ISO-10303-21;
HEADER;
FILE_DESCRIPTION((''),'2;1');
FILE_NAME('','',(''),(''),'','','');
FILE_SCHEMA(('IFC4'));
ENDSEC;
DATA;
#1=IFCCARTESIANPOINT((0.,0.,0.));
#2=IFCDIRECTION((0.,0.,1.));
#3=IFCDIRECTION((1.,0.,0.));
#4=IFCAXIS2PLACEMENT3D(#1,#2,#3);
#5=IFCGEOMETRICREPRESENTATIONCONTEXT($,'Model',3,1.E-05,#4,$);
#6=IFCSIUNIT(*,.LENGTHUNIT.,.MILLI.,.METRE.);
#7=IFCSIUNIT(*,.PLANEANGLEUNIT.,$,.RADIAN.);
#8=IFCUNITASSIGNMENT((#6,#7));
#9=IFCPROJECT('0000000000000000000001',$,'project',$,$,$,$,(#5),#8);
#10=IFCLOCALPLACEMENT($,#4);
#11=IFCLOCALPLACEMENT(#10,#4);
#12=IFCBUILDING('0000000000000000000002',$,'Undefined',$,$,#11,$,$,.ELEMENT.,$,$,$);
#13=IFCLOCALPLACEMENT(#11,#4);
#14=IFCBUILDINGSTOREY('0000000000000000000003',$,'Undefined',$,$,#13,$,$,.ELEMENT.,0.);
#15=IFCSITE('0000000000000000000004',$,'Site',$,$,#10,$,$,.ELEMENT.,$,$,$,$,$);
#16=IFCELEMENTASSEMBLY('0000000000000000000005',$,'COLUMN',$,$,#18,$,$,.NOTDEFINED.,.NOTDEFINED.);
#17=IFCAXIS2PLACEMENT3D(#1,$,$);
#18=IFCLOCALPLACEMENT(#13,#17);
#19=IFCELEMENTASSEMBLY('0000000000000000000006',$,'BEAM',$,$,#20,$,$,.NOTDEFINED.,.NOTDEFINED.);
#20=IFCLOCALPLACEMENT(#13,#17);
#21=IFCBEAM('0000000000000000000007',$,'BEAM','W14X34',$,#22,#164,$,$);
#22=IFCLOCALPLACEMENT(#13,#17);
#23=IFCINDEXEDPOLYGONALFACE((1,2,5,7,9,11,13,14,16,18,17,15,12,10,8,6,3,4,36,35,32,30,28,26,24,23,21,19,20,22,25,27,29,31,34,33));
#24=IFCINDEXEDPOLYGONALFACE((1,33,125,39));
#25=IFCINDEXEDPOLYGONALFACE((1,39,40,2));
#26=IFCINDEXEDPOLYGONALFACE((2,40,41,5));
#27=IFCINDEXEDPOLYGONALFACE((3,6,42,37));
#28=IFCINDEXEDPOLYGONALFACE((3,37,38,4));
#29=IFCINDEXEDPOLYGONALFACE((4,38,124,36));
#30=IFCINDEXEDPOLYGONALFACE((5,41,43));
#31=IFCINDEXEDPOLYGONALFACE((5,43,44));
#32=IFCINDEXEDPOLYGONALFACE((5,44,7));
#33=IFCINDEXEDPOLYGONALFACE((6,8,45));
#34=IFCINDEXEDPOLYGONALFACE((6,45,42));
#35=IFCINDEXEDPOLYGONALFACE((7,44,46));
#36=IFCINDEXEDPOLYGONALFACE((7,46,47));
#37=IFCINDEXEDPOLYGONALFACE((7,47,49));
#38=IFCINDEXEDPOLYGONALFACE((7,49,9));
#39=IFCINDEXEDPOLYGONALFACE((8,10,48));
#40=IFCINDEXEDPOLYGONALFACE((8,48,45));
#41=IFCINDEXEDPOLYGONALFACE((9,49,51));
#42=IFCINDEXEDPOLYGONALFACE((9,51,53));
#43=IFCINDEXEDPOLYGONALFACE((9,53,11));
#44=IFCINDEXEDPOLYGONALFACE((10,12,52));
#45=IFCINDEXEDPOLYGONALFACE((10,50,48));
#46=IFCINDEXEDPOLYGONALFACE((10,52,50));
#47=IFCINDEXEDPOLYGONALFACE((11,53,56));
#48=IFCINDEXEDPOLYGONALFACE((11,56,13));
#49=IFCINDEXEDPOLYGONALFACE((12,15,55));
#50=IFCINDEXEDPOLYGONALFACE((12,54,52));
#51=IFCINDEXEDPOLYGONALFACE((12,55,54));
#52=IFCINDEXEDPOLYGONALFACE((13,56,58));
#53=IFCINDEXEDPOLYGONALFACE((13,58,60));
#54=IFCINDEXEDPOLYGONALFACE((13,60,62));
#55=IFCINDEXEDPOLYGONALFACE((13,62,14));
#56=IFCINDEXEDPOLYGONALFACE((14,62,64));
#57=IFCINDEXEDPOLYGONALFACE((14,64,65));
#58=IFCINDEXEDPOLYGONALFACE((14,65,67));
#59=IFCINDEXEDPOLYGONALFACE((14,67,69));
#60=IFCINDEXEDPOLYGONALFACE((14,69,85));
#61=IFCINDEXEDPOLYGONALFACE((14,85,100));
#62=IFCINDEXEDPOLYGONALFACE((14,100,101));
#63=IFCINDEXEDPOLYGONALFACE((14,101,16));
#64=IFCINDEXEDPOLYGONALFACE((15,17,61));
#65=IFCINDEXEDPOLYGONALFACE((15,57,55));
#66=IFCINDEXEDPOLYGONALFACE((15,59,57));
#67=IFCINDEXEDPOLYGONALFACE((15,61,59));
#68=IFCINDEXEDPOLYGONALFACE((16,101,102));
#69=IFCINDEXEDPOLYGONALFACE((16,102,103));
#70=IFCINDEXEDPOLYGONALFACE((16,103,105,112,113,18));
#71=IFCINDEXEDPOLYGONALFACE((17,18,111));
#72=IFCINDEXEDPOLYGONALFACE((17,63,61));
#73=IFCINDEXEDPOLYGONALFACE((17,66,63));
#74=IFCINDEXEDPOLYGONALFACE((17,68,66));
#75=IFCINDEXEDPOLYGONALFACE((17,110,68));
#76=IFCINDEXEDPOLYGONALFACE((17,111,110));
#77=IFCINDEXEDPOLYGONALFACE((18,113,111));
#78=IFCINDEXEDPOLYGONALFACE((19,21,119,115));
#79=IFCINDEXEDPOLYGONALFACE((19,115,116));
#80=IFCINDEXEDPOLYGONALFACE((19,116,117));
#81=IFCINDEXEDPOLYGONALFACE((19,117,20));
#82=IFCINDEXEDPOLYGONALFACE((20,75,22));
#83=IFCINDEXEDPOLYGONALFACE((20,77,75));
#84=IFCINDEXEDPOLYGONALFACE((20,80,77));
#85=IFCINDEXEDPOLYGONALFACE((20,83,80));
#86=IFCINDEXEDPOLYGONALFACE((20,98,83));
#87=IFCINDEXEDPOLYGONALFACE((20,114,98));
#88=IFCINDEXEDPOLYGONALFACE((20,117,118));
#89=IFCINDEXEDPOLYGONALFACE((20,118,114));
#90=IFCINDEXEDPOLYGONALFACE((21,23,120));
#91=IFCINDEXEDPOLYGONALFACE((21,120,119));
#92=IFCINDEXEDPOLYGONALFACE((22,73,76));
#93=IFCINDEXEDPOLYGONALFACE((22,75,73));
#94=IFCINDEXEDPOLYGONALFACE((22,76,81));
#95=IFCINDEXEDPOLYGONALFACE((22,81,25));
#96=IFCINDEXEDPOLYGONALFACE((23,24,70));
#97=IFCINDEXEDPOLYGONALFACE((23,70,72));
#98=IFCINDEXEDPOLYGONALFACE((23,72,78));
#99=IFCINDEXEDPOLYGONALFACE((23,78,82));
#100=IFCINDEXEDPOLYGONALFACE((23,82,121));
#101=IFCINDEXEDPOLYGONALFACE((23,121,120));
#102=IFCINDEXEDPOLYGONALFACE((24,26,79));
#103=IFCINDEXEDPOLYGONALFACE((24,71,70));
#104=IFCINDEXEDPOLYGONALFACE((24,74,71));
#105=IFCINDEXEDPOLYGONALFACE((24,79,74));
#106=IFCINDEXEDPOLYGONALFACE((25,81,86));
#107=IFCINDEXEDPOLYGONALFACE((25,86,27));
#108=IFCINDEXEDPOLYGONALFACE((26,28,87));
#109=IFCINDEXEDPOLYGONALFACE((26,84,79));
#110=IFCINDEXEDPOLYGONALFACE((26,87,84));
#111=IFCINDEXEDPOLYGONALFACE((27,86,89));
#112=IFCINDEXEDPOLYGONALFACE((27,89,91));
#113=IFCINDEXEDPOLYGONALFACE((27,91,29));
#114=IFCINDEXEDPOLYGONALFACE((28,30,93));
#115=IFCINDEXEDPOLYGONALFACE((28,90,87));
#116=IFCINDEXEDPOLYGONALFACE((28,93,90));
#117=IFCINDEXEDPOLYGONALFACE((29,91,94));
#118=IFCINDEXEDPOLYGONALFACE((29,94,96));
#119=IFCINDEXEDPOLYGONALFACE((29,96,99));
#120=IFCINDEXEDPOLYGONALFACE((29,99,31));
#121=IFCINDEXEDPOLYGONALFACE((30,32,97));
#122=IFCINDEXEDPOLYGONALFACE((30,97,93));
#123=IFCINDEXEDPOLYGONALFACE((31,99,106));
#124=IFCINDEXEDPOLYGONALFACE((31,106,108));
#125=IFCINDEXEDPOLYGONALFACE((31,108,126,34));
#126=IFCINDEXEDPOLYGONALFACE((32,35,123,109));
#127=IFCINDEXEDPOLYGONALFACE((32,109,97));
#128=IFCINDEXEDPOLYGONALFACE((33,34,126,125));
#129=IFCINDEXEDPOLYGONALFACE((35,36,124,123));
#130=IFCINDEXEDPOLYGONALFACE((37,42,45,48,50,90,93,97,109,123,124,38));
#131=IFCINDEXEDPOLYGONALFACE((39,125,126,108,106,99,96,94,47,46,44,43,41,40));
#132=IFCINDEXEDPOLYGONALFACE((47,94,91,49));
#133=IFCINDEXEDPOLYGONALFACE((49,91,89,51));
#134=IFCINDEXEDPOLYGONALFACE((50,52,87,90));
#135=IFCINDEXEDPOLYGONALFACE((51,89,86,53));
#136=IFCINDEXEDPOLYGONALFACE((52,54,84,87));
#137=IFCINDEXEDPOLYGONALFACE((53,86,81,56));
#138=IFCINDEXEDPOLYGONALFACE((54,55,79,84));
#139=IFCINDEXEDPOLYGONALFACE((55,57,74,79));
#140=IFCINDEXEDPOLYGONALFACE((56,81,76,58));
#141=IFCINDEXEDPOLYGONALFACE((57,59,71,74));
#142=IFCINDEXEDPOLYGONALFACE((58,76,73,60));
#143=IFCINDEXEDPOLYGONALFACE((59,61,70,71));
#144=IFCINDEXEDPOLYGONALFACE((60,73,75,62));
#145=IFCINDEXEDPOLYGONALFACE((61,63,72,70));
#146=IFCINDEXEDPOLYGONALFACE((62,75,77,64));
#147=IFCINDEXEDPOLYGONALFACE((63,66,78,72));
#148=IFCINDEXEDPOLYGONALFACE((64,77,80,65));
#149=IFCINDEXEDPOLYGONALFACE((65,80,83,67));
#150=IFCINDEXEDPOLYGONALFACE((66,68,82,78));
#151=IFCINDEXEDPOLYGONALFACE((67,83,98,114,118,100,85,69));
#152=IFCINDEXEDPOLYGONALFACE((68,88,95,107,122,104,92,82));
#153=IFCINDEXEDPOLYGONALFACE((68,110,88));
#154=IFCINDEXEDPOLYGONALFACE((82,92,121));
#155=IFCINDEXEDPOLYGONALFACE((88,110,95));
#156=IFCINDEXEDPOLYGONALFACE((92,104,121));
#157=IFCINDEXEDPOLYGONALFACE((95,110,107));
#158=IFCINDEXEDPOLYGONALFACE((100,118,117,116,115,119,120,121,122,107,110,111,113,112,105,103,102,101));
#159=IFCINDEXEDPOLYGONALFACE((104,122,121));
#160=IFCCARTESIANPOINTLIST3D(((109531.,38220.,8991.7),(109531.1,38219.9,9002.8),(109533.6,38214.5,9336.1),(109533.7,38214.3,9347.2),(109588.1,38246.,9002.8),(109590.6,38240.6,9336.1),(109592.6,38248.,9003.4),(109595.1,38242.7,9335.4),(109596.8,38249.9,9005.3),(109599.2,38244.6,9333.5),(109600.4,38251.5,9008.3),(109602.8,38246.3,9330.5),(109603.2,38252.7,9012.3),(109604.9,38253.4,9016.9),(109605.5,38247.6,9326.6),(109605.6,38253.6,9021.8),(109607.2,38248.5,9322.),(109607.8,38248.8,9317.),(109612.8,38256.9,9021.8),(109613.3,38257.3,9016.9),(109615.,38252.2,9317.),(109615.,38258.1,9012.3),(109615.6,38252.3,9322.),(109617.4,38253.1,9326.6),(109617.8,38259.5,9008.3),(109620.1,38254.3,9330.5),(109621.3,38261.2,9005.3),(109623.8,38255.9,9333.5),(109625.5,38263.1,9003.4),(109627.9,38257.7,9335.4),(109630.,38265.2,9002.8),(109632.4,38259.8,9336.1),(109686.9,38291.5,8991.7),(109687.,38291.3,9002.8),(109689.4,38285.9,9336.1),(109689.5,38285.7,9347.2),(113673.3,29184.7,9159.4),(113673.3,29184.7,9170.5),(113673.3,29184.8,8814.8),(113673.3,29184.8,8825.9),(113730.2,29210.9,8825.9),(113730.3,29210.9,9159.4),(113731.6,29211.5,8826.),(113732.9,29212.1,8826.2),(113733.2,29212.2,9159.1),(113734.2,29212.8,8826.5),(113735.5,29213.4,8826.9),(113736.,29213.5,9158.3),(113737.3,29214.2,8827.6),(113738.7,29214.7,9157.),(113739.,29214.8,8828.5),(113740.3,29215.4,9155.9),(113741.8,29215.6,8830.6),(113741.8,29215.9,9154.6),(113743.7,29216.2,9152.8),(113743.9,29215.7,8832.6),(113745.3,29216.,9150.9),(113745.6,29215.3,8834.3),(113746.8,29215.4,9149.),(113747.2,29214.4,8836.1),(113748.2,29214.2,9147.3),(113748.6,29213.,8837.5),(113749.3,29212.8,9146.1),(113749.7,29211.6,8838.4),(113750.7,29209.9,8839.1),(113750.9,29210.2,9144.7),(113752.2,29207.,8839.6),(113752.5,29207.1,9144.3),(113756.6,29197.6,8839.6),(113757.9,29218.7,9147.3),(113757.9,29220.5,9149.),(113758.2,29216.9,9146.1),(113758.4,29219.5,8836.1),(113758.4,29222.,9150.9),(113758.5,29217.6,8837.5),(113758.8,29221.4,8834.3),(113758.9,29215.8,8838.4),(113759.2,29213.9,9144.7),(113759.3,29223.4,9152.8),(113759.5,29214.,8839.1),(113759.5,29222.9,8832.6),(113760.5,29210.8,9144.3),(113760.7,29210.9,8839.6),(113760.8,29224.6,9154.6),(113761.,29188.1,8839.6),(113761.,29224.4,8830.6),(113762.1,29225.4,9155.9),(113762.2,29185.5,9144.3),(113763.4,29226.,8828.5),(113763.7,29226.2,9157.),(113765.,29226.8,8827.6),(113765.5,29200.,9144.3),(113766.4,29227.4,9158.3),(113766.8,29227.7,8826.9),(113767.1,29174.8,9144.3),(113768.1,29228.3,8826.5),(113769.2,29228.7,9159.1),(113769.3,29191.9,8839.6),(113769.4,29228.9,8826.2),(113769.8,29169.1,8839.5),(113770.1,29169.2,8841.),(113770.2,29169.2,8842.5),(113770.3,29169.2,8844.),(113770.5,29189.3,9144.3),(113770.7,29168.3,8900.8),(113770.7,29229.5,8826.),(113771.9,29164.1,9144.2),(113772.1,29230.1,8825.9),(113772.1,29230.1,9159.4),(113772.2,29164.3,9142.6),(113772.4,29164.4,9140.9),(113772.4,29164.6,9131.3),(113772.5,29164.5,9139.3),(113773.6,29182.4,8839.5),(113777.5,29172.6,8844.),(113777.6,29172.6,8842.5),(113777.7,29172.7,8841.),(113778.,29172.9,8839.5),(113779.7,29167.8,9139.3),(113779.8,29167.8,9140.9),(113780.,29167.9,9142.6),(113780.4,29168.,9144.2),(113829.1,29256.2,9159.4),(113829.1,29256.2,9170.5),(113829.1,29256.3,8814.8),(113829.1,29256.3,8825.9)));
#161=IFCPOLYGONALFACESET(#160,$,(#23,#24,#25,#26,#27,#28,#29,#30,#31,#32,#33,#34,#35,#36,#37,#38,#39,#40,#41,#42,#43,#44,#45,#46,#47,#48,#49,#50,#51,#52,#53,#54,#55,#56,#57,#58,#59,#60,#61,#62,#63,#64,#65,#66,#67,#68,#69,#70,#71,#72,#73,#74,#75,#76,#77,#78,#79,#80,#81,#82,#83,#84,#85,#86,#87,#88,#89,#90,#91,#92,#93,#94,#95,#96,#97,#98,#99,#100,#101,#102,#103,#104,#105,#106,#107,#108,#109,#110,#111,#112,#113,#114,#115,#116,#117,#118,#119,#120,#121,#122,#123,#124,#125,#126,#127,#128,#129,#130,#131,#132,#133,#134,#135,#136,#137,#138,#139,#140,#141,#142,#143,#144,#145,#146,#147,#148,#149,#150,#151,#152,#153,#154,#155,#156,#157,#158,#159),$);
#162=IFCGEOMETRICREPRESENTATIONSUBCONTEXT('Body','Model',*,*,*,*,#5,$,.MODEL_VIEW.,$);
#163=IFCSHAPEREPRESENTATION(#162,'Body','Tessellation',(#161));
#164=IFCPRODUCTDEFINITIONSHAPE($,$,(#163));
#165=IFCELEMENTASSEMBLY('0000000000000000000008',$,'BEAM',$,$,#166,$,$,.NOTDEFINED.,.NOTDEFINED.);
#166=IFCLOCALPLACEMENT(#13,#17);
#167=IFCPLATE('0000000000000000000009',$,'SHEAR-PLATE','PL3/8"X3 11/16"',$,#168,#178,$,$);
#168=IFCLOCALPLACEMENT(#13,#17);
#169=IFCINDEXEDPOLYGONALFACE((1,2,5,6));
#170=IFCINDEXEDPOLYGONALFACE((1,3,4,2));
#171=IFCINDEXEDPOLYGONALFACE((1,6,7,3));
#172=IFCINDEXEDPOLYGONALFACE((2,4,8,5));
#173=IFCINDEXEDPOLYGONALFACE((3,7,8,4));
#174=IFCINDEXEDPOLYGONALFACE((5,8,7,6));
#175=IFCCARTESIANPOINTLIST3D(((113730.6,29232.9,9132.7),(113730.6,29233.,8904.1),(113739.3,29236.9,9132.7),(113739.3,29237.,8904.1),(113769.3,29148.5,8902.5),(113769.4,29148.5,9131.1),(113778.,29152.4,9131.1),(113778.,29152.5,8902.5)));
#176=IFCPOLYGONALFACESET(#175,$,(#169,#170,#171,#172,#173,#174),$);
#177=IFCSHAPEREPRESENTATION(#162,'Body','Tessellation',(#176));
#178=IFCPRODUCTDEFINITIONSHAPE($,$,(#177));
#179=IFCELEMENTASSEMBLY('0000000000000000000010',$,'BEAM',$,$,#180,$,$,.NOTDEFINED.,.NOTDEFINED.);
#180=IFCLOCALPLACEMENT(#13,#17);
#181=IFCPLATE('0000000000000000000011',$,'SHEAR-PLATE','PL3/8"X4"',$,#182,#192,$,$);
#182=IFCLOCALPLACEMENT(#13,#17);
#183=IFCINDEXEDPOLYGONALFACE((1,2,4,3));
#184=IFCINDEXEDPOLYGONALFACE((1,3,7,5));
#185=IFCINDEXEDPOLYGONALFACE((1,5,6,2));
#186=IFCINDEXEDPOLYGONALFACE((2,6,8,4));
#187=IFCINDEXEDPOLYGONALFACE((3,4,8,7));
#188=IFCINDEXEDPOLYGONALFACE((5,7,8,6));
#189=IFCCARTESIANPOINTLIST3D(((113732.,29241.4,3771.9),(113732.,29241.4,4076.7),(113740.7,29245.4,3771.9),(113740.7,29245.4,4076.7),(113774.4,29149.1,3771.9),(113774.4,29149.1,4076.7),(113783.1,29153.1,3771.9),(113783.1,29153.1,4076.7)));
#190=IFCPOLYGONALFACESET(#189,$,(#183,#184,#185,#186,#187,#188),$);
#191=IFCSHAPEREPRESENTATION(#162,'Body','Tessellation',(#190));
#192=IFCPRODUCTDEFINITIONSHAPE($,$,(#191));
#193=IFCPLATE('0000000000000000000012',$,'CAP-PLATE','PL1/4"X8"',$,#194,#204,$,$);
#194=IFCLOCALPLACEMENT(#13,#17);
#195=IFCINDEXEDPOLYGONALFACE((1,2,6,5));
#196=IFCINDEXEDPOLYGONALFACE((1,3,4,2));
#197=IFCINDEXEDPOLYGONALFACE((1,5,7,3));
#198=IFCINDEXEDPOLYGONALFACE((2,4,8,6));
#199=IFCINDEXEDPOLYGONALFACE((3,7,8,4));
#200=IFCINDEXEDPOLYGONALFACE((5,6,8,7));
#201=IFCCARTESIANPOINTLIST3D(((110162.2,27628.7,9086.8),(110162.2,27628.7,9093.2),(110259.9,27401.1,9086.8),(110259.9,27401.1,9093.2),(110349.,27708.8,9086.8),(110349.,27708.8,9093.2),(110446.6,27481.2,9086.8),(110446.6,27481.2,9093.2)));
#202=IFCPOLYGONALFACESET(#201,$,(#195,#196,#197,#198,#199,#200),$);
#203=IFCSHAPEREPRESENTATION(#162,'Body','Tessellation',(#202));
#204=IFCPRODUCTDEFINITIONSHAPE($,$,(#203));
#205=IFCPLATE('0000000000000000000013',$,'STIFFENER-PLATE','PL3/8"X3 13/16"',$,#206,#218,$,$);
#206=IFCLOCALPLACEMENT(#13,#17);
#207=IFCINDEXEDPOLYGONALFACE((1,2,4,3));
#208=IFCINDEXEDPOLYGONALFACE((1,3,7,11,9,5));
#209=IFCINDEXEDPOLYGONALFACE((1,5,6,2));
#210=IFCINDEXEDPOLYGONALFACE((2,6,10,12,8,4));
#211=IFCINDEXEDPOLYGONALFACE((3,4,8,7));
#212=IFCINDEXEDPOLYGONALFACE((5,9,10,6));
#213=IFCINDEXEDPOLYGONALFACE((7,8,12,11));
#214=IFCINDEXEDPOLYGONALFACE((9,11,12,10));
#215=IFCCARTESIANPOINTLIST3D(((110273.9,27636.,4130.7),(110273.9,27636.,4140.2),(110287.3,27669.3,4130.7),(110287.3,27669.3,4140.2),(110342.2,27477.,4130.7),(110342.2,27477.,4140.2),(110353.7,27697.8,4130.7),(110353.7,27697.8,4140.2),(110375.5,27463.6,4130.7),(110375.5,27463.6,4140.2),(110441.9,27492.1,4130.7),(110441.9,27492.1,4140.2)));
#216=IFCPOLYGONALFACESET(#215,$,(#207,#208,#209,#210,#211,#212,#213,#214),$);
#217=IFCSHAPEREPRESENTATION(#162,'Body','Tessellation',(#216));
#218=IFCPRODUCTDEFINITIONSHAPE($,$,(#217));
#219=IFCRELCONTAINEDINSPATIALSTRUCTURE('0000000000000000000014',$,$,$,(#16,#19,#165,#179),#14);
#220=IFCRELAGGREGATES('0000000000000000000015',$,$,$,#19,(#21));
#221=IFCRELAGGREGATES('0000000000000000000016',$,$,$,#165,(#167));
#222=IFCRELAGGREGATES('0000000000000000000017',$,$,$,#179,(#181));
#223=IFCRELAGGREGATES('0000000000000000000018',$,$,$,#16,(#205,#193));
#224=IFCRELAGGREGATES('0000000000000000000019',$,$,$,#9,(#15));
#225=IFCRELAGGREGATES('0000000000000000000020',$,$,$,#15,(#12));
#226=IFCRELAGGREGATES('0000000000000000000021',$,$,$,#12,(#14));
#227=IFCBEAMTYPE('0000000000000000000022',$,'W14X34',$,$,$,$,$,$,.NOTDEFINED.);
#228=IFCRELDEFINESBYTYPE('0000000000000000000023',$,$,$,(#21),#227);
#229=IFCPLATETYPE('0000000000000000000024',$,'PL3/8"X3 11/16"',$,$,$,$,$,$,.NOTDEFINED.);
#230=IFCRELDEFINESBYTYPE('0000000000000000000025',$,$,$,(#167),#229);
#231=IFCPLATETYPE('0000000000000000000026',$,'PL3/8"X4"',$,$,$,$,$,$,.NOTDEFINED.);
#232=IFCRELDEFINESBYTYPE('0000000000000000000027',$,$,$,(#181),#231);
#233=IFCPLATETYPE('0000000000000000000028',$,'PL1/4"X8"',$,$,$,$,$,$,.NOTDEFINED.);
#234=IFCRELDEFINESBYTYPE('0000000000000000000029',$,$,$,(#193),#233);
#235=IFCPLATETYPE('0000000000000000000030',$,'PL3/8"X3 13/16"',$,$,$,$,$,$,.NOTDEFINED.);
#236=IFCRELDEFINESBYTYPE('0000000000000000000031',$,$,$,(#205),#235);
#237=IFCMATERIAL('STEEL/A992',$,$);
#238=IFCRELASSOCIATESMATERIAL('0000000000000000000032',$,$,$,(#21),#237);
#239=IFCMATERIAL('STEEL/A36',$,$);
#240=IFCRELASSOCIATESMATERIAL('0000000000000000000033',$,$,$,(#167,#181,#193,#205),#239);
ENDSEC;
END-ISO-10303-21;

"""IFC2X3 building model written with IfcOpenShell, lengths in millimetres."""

from ifc_helpers import new_model, si_unit, frame, frame_2d, origin_with_axes, origin_2d_with_axis, place, context, subcontext, project, spatial, polyline, circle_curve, parameter, trimmed, segment, composite_curve, rectangle, i_section, outline, extrude, boolean, halfspace, material, type_object, element, aggregate, save


model = new_model("IFC2X3")

# Units and contexts
model_context = context("Model", 3, precision=1e-05, world=origin_with_axes())
body_context = subcontext(model_context, "Body", "Model", "MODEL_VIEW")
ifc_project = project(units=[si_unit("LENGTHUNIT", "METRE", prefix="MILLI"), si_unit("PLANEANGLEUNIT", "RADIAN")], contexts=[model_context])

# Site, building, storey
site_placement = place(None, origin_with_axes())
site = spatial("IfcSite", under=ifc_project, at=site_placement, Name="Site", CompositionType="ELEMENT")
building_placement = place(site_placement, origin_with_axes())
building = spatial("IfcBuilding", under=site, at=building_placement, Name="Undefined", CompositionType="ELEMENT")
storey_placement = place(building_placement, origin_with_axes())
storey = spatial("IfcBuildingStorey", under=building, at=storey_placement, Name="Undefined", CompositionType="ELEMENT", Elevation=0.0)

# Element assembly
assembly_1_placement = place(storey_placement, origin_with_axes())
assembly_1 = element("IfcElementAssembly", 1, at=assembly_1_placement, inside=storey, Name="COLUMN", AssemblyPlace="NOTDEFINED", PredefinedType="NOTDEFINED")
ifc_material_1 = material(Name="STEEL/A36")

# Element assembly, beam
ifc_material_2 = material(Name="STEEL/A992")
assembly_2_placement = place(storey_placement, origin_with_axes())
assembly_2 = element("IfcElementAssembly", 2, at=assembly_2_placement, inside=storey, Name="BEAM", AssemblyPlace="NOTDEFINED", PredefinedType="NOTDEFINED")
beam_type_1 = type_object("IfcBeamType", Name="W14X34", PredefinedType="NOTDEFINED")
beam_1_placement = place(assembly_2_placement, frame((113782.5, 29152.2, 8991.3), z_axis=(0.007413, -0.016169, 0.999842), x_axis=(-0.416677, 0.908881, 0.017787)))
beam_1 = element("IfcBeam", 3, at=beam_1_placement, type_object=beam_type_1, material=ifc_material_2, Name="BEAM", Description="W14X34", context=body_context, shape_type="CSG", body=[
    boolean("DIFFERENCE", boolean("DIFFERENCE", boolean("DIFFERENCE", boolean("DIFFERENCE", extrude(i_section(OverallWidth=171.4, OverallDepth=355.6, WebThickness=7.9, FlangeThickness=11.1, FilletRadius=19.1, at=origin_2d_with_axis()), frame((10013.1, 0.0, 0.0), z_axis=(-1.0, 0.0, 0.0), x_axis=(0.0, -1.0, 0.0)), (0.0, 0.0, 1.0), 10096.8), extrude(outline(composite_curve([segment(polyline([(0.0, 0.0), (51.8, 0.0)]), True, "CONTINUOUS"), segment(trimmed(circle_curve(frame_2d((51.8, 12.7), x_axis=(0.0, -1.0)), 12.7), [parameter(0.0)], [parameter(1.570796)], True, "PARAMETER"), True, "CONTINUOUS"), segment(polyline([(64.5, 12.7), (64.5, 34.7), (0.6, 35.9), (0.0, 0.0)]), True, "CONTINUOUS")], self_intersect=True)), frame((8.0, -95.7, -151.9), z_axis=(-0.000369, 1.0, 0.0), x_axis=(0.999846, 0.000369, -0.017567)), (0.0, 0.0, 1.0), 191.5)), extrude(outline(composite_curve([segment(polyline([(0.0, 0.0), (57.2, 0.0)]), True, "CONTINUOUS"), segment(trimmed(circle_curve(frame_2d((57.2, 12.7), x_axis=(0.0, -1.0)), 12.7), [parameter(0.0)], [parameter(1.570796)], True, "PARAMETER"), True, "CONTINUOUS"), segment(polyline([(69.9, 12.7), (69.9, 36.2), (-0.6, 35.0), (0.0, 0.0)]), True, "CONTINUOUS")], self_intersect=True)), frame((7.9, 95.8, 152.8), z_axis=(0.000369, -1.0, 0.0), x_axis=(0.999846, 0.000369, -0.017567)), (0.0, 0.0, 1.0), 191.5)), extrude(rectangle(XDim=122.0, YDim=122.0, at=origin_2d_with_axis()), frame((51.5, 65.0, -90.9), z_axis=(0.0, 0.0, 1.0), x_axis=(-1.0, 0.0, 0.0)), (0.0, 0.0, 1.0), 230.6)), halfspace(frame((18.0, 0.0, 177.8), z_axis=(-1.0, 0.0, 0.0), x_axis=(0.0, -1.0, 0.0)), False)),
])
aggregate(assembly_2, [beam_1])

# Element assemblies, plates
assembly_3_placement = place(storey_placement, origin_with_axes())
assembly_3 = element("IfcElementAssembly", 4, at=assembly_3_placement, inside=storey, Name="BEAM", AssemblyPlace="NOTDEFINED", PredefinedType="NOTDEFINED")
plate_type_1 = type_object("IfcPlateType", Name="PL3/8\"X3 11/16\"", PredefinedType="NOTDEFINED")
plate_1_placement = place(assembly_3_placement, frame((113773.7, 29150.4, 9131.1), z_axis=(0.909024, 0.416743, 0.0), x_axis=(-0.000092, 0.0002, -1.0)))
plate_1 = element("IfcPlate", 5, at=plate_1_placement, type_object=plate_type_1, material=ifc_material_1, Name="SHEAR-PLATE", Description="PL3/8\"X3 11/16\"", context=body_context, shape_type="SweptSolid", body=[
    extrude(outline(polyline([(0.0, 0.0), (228.6, 0.0), (227.0, 92.9), (-1.6, 92.9), (0.0, 0.0)])), frame((0.0, 0.0, -4.8), z_axis=(0.0, 0.0, 1.0), x_axis=(1.0, 0.0, 0.0)), (0.0, 0.0, 1.0), 9.5),
])
aggregate(assembly_3, [plate_1])
assembly_4_placement = place(storey_placement, origin_with_axes())
assembly_4 = element("IfcElementAssembly", 6, at=assembly_4_placement, inside=storey, Name="BEAM", AssemblyPlace="NOTDEFINED", PredefinedType="NOTDEFINED")
plate_type_2 = type_object("IfcPlateType", Name="PL3/8\"X4\"", PredefinedType="NOTDEFINED")
plate_2_placement = place(assembly_4_placement, frame((113778.7, 29151.1, 4076.7), z_axis=(0.908684, 0.417484, 0.0), x_axis=(0.0, 0.0, -1.0)))
plate_2 = element("IfcPlate", 7, at=plate_2_placement, type_object=plate_type_2, material=ifc_material_1, Name="SHEAR-PLATE", Description="PL3/8\"X4\"", context=body_context, shape_type="SweptSolid", body=[
    extrude(outline(polyline([(0.0, 0.0), (304.8, 0.0), (304.8, 101.6), (0.0, 101.6), (0.0, 0.0)])), frame((0.0, 0.0, -4.8), z_axis=(0.0, 0.0, 1.0), x_axis=(1.0, 0.0, 0.0)), (0.0, 0.0, 1.0), 9.5),
])
aggregate(assembly_4, [plate_2])

# Plates
plate_type_3 = type_object("IfcPlateType", Name="PL1/4\"X8\"", PredefinedType="NOTDEFINED")
plate_3_placement = place(assembly_1_placement, frame((110353.2, 27441.1, 9090.0), z_axis=(0.0, 0.0, -1.0), x_axis=(-0.394254, 0.919001, 0.0)))
plate_3 = element("IfcPlate", 8, at=plate_3_placement, type_object=plate_type_3, material=ifc_material_1, Name="CAP-PLATE", Description="PL1/4\"X8\"", context=body_context, shape_type="SweptSolid", body=[
    extrude(outline(polyline([(0.0, -101.6), (0.0, 101.6), (247.6, 101.6), (247.6, -101.6), (0.0, -101.6)])), frame((0.0, 0.0, -3.2), z_axis=(0.0, 0.0, 1.0), x_axis=(1.0, 0.0, 0.0)), (0.0, 0.0, 1.0), 6.4),
])
plate_type_4 = type_object("IfcPlateType", Name="PL3/8\"X3 13/16\"", PredefinedType="NOTDEFINED")
plate_4_placement = place(assembly_1_placement, frame((110352.2, 27453.6, 4135.4), z_axis=(0.0, 0.0, 1.0), x_axis=(0.919001, 0.394254, 0.0)))
plate_4 = element("IfcPlate", 9, at=plate_4_placement, type_object=plate_type_4, material=ifc_material_1, Name="STIFFENER-PLATE", Description="PL3/8\"X3 13/16\"", context=body_context, shape_type="SweptSolid", body=[
    extrude(outline(polyline([(0.0, 25.4), (25.4, 0.0), (97.6, 0.0), (97.6, 223.8), (25.4, 223.8), (0.0, 198.4), (0.0, 25.4)])), frame((0.0, 0.0, -4.8), z_axis=(0.0, 0.0, 1.0), x_axis=(1.0, 0.0, 0.0)), (0.0, 0.0, 1.0), 9.5),
])
aggregate(assembly_1, [plate_4, plate_3])

save(model, "model.ifc")
